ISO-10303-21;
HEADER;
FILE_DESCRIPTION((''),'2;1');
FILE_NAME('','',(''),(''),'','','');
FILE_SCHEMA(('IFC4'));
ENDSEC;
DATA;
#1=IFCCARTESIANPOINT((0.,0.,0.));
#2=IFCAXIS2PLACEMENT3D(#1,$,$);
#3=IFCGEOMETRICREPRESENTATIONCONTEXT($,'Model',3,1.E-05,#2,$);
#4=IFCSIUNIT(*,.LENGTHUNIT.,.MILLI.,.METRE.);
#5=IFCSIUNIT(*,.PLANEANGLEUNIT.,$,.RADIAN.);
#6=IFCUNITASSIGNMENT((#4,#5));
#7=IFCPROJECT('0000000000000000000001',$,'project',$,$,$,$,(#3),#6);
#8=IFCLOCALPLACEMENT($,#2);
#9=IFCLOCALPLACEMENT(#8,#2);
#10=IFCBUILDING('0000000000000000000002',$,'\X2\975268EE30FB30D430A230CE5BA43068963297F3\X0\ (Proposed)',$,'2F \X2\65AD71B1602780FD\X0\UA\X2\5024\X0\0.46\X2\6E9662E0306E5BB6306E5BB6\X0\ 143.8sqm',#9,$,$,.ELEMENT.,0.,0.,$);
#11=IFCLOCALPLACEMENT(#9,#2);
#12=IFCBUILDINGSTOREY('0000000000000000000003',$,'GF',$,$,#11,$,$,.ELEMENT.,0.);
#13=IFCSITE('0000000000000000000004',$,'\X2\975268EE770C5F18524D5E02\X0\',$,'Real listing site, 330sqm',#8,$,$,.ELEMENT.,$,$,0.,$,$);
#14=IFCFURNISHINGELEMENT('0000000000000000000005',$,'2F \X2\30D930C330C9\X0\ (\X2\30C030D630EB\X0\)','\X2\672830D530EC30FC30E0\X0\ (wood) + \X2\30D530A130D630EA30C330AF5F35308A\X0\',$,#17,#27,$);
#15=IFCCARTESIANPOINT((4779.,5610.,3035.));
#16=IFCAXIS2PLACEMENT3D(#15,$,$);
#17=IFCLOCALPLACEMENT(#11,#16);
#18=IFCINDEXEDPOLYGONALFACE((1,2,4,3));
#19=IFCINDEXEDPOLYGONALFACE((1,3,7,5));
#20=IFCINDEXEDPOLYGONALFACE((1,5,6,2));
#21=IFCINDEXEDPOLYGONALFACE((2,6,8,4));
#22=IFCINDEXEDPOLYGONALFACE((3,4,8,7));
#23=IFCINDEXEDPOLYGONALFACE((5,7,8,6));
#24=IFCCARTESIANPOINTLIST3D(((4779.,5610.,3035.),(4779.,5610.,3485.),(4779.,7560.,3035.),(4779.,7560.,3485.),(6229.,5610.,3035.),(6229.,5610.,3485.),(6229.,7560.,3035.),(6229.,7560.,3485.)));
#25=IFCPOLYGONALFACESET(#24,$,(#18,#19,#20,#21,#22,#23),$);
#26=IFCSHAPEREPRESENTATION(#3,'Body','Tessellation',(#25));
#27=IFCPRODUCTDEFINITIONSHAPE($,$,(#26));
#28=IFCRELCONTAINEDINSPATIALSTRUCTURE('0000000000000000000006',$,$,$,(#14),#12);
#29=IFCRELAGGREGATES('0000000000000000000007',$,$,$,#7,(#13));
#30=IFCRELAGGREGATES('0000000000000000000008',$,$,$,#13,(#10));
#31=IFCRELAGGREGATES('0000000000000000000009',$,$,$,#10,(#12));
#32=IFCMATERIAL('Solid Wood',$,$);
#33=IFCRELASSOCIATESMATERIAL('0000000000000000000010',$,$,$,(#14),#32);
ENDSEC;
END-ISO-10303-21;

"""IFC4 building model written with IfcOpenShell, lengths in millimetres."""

from ifc_helpers import new_model, si_unit, frame, frame_2d, origin, place, context, project, spatial, rectangle, extrude, material, element, save


model = new_model("IFC4")

# Units and contexts
model_context = context("Model", 3, precision=1e-05, world=origin())
ifc_project = project(units=[si_unit("LENGTHUNIT", "METRE", prefix="MILLI"), si_unit("PLANEANGLEUNIT", "RADIAN")], contexts=[model_context])

# Site, building, storey
site_placement = place(None, origin())
site = spatial("IfcSite", under=ifc_project, at=site_placement, Name="青森県弘前市", ObjectType="Real listing site, 330sqm", CompositionType="ELEMENT", RefElevation=0.0)
building_placement = place(site_placement, origin())
building = spatial("IfcBuilding", under=site, at=building_placement, Name="青森・ピアノ室と防音 (Proposed)", ObjectType="2F 断熱性能UA値0.46準拠の家の家 143.8sqm", CompositionType="ELEMENT", ElevationOfRefHeight=0.0, ElevationOfTerrain=0.0)
storey_placement = place(building_placement, origin())
storey = spatial("IfcBuildingStorey", under=building, at=storey_placement, Name="GF", CompositionType="ELEMENT", Elevation=0.0)

# Shared definitions
ifc_material_1 = material(Name="Solid Wood")

# Furnishing element
furnishing_1_placement = place(storey_placement, frame((4779.0, 5610.0, 3035.0)))
element("IfcFurnishingElement", 1, at=furnishing_1_placement, inside=storey, material=ifc_material_1, Name="2F ベッド (ダブル)", Description="木フレーム (wood) + ファブリック張り", context=model_context, shape_type="SweptSolid", body=[
    extrude(rectangle(XDim=1450.0, YDim=1950.0, at=frame_2d((725.0, 975.0))), frame((4779.0, 5610.0, 3035.0)), (0.0, 0.0, 1.0), 450.0),
])

save(model, "model.ifc")
